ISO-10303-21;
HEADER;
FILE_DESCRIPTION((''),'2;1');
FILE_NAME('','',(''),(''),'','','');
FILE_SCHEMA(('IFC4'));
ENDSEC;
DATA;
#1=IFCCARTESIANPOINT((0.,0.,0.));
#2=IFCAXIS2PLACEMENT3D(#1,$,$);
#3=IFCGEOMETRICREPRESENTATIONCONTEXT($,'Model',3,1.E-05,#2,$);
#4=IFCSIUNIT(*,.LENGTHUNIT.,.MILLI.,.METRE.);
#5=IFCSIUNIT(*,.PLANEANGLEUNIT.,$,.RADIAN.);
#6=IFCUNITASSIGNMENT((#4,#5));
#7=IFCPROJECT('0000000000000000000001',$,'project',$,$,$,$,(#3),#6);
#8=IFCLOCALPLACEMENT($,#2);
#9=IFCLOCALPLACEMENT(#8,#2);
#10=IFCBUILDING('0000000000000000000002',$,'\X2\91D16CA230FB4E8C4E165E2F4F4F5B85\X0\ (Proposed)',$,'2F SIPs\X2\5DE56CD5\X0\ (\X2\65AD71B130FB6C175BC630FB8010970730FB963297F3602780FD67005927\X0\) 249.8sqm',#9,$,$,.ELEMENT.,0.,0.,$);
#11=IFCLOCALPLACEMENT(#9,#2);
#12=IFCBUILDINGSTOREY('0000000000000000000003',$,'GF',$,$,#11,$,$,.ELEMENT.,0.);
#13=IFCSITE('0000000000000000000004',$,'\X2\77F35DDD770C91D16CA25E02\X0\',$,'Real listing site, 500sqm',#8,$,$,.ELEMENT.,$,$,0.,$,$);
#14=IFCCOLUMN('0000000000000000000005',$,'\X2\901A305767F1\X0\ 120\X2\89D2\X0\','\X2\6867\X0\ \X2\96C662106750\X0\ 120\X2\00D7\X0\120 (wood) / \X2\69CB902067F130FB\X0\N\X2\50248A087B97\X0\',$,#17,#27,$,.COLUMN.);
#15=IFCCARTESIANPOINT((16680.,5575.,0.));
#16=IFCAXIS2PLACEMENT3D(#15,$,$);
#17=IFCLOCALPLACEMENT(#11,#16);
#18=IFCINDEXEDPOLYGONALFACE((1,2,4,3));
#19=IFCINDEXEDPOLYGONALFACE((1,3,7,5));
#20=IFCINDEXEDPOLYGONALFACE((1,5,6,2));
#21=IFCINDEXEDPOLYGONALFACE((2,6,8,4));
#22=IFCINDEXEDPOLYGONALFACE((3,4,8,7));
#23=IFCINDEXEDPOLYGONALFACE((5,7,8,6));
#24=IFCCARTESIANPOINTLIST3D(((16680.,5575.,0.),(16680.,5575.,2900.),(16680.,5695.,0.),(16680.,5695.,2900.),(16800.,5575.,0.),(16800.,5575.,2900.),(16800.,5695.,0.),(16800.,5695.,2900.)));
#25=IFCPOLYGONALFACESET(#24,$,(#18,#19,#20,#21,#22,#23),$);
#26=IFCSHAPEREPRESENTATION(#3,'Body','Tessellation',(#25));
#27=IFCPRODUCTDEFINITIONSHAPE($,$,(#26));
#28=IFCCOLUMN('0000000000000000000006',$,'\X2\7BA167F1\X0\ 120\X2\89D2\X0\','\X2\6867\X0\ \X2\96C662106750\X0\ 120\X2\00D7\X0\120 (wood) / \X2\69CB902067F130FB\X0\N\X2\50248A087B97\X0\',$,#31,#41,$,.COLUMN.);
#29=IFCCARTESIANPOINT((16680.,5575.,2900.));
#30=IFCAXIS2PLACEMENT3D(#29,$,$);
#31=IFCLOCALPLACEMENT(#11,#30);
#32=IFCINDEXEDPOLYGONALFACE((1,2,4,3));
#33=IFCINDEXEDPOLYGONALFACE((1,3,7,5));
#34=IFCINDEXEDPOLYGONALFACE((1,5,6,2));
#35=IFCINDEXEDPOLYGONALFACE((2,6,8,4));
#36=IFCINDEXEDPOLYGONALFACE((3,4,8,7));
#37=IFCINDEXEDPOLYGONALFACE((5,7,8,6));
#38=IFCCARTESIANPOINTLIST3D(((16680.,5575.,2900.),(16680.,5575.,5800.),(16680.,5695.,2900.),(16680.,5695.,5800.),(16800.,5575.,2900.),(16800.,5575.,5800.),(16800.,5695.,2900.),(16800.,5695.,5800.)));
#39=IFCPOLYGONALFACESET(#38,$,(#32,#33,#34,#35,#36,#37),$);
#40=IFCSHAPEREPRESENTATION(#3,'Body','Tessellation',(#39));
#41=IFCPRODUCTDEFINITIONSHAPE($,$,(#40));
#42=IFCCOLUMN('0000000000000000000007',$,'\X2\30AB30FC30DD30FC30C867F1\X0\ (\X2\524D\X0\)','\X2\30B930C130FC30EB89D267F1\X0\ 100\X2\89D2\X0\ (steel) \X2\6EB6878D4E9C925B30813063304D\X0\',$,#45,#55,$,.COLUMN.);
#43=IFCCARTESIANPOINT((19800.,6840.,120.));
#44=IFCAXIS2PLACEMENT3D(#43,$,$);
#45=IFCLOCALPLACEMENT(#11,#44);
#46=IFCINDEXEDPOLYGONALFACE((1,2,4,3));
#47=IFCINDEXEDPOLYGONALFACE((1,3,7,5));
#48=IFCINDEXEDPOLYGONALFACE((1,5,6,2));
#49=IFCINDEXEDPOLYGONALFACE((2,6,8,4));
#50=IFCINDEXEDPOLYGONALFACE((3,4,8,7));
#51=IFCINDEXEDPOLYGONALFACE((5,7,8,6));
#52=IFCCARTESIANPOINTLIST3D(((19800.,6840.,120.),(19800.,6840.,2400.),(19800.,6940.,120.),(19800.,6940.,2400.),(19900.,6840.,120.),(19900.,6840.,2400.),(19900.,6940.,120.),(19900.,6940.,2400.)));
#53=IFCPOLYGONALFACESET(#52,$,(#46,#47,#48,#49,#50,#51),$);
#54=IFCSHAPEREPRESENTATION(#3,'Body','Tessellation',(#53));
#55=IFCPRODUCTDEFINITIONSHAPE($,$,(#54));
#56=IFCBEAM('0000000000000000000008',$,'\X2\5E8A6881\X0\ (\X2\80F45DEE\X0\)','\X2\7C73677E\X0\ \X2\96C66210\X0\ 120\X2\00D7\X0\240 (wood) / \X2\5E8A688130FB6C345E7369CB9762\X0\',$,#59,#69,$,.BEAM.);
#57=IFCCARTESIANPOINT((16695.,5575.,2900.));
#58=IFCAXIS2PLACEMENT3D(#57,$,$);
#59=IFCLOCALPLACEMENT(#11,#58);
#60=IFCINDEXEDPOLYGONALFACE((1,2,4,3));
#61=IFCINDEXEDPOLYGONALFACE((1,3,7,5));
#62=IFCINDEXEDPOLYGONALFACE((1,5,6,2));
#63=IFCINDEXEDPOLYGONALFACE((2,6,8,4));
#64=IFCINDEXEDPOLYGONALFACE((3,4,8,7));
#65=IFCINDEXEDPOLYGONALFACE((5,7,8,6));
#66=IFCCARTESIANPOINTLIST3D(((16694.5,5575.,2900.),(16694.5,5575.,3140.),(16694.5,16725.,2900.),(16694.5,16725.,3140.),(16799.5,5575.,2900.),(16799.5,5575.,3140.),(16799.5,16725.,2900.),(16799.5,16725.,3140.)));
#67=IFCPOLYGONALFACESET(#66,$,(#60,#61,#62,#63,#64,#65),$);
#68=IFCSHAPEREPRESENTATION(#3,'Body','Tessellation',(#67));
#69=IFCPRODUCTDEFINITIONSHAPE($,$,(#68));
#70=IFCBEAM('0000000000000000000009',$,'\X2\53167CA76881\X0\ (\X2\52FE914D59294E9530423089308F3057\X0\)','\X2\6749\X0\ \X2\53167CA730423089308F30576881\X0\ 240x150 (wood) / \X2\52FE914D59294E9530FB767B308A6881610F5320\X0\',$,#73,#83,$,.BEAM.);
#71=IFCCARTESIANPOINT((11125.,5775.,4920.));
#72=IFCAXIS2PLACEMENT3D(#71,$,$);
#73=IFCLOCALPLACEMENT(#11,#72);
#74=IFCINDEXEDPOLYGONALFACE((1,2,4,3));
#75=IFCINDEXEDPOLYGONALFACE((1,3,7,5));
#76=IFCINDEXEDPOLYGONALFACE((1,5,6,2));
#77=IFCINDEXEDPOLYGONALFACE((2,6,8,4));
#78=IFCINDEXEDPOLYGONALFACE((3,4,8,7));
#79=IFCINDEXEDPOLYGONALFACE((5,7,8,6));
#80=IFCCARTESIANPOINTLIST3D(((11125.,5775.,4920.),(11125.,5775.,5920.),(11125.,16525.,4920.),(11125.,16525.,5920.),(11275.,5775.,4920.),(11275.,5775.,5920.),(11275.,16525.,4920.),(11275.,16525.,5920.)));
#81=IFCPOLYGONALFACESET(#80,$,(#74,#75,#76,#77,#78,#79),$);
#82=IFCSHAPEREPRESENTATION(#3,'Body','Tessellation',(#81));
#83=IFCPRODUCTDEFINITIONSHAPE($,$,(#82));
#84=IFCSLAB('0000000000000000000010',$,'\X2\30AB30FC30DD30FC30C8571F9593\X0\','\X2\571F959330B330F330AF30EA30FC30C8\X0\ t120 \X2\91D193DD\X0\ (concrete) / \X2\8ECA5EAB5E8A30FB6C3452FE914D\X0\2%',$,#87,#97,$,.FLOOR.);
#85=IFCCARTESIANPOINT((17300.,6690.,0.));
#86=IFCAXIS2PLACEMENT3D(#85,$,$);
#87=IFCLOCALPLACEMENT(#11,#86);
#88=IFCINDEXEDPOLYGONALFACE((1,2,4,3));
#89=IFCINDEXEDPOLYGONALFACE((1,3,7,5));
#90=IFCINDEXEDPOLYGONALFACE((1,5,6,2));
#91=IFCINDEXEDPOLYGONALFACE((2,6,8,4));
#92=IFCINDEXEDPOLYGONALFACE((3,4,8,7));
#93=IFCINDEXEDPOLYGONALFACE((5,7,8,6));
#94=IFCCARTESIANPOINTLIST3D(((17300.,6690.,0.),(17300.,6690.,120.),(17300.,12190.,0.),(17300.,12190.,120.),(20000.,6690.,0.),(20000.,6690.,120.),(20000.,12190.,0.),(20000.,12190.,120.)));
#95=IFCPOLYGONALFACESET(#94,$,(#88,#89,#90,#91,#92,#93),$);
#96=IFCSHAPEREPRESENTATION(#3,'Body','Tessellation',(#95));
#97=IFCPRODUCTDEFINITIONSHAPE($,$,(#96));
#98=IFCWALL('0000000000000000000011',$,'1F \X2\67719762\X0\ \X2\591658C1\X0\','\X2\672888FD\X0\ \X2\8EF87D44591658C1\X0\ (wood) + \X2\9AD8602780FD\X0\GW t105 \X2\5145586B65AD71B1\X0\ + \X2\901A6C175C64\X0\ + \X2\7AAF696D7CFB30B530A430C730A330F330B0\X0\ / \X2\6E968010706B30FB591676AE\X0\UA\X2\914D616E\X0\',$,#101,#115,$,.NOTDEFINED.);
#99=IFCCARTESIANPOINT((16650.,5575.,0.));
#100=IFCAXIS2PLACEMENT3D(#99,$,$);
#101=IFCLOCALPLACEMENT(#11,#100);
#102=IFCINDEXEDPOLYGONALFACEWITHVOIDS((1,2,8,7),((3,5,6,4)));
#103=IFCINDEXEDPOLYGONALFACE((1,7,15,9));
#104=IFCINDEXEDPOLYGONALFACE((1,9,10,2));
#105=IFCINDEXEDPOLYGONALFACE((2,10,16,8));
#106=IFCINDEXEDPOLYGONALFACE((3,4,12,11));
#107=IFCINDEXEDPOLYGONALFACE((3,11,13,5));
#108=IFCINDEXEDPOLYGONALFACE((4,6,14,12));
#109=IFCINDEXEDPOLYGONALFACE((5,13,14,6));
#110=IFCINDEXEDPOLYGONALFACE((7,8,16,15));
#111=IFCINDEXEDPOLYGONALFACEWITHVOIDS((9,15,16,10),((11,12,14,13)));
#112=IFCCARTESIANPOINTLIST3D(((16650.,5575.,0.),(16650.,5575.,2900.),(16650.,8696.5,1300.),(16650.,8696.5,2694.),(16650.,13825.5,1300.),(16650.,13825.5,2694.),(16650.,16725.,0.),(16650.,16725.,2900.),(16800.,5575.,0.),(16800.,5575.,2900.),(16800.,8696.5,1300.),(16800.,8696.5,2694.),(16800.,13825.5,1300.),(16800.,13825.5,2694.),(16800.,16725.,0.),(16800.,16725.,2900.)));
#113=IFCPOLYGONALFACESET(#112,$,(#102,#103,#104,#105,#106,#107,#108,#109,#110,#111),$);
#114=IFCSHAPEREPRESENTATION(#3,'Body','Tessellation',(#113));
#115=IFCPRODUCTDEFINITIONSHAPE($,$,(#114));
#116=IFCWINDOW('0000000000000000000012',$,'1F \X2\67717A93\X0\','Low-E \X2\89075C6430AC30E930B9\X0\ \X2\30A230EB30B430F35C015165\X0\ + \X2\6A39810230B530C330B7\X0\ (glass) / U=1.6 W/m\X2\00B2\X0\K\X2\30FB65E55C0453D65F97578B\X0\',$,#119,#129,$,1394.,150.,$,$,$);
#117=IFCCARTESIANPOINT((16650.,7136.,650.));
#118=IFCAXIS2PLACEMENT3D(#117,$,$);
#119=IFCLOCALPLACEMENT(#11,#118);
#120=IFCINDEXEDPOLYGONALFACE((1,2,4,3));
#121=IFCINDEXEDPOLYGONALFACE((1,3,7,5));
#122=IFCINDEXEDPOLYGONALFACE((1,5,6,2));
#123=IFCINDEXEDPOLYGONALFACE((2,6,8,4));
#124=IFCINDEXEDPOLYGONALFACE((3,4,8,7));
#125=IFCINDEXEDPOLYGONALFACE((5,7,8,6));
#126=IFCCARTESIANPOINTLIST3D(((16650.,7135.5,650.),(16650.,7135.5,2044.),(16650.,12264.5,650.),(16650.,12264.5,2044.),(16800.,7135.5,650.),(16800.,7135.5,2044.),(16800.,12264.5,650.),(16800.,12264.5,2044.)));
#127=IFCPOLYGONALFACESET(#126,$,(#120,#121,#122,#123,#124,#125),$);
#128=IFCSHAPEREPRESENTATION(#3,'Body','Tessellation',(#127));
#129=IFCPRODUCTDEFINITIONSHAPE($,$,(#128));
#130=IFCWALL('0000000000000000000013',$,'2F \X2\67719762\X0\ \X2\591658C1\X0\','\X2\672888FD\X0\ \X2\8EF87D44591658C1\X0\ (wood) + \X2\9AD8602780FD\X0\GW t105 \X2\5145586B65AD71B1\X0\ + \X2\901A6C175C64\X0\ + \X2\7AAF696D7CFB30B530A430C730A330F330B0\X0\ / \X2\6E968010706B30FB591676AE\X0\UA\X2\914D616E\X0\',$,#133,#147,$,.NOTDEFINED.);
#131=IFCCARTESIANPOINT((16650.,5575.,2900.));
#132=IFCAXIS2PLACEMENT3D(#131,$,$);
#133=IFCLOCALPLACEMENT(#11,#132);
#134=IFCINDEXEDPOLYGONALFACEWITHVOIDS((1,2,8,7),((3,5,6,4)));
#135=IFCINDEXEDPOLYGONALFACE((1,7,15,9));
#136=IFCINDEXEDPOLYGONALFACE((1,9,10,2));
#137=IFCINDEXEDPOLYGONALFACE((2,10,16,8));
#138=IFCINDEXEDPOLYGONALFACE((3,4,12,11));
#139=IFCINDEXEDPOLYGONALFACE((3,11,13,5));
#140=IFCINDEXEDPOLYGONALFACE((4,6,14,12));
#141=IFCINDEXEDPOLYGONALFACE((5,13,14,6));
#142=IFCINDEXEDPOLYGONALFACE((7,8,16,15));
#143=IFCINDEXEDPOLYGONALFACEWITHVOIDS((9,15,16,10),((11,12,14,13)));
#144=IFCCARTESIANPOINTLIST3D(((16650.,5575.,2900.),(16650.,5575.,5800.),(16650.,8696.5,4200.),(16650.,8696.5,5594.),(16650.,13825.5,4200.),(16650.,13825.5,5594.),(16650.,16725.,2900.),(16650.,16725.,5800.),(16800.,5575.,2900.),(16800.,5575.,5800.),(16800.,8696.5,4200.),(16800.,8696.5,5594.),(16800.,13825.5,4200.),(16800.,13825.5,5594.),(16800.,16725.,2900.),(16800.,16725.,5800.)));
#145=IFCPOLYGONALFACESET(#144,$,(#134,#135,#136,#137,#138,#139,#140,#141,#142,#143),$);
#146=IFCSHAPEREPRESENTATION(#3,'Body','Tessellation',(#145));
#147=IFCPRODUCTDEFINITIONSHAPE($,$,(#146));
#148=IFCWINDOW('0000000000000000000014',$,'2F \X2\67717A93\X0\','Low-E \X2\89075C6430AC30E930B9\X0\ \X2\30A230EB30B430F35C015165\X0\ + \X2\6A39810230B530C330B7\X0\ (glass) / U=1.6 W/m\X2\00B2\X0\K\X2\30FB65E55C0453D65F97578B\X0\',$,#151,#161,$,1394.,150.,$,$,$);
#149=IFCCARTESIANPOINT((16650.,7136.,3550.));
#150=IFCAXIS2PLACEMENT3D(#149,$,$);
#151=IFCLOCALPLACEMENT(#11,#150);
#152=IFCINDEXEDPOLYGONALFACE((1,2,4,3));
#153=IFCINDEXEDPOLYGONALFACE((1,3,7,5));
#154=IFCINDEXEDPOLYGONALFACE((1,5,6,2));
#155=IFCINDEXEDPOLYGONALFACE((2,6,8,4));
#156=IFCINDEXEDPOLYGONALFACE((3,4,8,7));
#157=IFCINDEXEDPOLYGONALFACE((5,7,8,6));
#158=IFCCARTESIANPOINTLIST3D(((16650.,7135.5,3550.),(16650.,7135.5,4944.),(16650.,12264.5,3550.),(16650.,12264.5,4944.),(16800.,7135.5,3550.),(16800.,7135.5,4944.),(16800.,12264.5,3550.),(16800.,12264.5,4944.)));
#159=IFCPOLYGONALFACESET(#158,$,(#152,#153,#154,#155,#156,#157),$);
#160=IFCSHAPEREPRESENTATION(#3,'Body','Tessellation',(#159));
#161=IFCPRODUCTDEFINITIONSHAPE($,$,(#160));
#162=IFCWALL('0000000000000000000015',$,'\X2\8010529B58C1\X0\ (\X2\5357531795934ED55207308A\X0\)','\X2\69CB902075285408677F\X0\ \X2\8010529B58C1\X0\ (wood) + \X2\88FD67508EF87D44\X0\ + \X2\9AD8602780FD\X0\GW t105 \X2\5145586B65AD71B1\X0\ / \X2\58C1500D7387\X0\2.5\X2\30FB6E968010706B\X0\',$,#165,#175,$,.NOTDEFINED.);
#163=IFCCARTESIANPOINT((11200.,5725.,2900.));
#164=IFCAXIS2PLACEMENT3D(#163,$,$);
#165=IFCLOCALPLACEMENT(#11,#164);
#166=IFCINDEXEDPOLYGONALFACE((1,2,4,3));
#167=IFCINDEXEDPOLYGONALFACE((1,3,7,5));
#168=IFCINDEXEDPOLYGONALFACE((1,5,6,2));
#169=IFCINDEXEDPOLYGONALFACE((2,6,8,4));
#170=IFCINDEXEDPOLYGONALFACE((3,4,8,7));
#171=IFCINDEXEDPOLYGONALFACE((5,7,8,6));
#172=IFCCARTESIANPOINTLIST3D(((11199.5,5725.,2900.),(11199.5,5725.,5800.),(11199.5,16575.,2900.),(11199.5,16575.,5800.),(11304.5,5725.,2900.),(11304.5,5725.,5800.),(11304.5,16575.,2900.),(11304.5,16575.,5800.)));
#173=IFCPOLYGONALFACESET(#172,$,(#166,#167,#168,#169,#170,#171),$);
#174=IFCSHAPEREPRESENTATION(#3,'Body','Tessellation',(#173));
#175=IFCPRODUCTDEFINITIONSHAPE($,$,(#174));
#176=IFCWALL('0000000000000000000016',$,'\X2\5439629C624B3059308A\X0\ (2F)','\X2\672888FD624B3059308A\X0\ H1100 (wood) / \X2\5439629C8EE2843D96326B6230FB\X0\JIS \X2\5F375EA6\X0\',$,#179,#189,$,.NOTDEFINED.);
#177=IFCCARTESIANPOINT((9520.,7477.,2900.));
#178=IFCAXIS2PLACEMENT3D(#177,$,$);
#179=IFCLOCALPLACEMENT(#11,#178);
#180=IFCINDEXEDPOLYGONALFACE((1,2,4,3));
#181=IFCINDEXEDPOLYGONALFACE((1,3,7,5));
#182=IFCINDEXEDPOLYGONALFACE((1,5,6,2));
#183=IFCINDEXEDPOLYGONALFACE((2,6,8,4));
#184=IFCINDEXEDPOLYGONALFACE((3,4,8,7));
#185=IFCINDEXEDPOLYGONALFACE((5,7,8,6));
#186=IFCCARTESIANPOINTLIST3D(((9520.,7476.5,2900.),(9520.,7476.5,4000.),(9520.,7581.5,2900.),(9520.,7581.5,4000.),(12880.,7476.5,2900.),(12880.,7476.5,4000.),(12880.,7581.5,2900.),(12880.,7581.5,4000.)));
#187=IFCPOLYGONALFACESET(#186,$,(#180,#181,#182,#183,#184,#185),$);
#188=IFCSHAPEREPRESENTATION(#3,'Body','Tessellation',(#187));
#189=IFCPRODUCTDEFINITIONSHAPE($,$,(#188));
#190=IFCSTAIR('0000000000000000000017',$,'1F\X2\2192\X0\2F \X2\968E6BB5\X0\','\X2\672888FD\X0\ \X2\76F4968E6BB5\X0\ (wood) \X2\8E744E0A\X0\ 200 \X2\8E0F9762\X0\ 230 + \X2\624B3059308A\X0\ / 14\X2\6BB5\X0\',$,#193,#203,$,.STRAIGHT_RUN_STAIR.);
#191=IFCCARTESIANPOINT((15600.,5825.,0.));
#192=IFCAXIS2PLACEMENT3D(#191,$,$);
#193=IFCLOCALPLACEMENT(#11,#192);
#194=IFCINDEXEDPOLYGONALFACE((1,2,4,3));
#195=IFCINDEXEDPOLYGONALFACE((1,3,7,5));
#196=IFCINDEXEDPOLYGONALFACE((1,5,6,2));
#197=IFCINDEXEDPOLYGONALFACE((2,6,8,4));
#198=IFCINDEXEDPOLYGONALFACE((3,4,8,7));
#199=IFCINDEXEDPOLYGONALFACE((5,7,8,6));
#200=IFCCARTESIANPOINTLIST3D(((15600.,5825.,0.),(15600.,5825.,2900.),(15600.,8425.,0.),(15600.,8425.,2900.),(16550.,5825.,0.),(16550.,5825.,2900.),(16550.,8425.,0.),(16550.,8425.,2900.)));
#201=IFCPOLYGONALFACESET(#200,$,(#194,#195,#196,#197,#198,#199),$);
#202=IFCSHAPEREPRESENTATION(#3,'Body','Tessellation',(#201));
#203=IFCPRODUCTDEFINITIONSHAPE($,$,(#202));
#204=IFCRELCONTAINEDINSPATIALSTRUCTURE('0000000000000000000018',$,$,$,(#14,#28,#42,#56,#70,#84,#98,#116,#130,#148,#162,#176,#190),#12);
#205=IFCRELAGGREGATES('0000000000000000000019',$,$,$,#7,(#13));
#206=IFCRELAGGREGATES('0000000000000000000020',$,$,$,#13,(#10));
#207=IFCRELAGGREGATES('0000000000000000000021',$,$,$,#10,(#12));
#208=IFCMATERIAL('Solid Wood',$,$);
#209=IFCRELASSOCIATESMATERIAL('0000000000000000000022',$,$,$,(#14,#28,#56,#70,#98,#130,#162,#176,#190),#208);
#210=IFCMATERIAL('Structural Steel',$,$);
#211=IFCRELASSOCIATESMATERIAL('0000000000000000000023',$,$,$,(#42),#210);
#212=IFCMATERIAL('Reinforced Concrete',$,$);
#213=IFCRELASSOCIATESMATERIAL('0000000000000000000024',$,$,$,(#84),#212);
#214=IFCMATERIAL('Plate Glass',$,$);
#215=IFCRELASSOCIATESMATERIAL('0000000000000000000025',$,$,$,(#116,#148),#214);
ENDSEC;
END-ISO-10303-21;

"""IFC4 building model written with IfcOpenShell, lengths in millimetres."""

from ifc_helpers import new_model, si_unit, frame, frame_2d, origin, place, context, project, spatial, rectangle, extrude, material, element, fill, save


model = new_model("IFC4")

# Units and contexts
model_context = context("Model", 3, precision=1e-05, world=origin())
ifc_project = project(units=[si_unit("LENGTHUNIT", "METRE", prefix="MILLI"), si_unit("PLANEANGLEUNIT", "RADIAN")], contexts=[model_context])

# Site, building, storey
site_placement = place(None, origin())
site = spatial("IfcSite", under=ifc_project, at=site_placement, Name="石川県金沢市", ObjectType="Real listing site, 500sqm", CompositionType="ELEMENT", RefElevation=0.0)
building_placement = place(site_placement, origin())
building = spatial("IfcBuilding", under=site, at=building_placement, Name="金沢・二世帯住宅 (Proposed)", ObjectType="2F SIPs工法 (断熱・気密・耐震・防音性能最大) 249.8sqm", CompositionType="ELEMENT", ElevationOfRefHeight=0.0, ElevationOfTerrain=0.0)
storey_placement = place(building_placement, origin())
storey = spatial("IfcBuildingStorey", under=building, at=storey_placement, Name="GF", CompositionType="ELEMENT", Elevation=0.0)

# Columns
ifc_material_1 = material(Name="Solid Wood")
column_1_placement = place(storey_placement, frame((16680.0, 5575.0, 0.0)))
element("IfcColumn", 1, at=column_1_placement, inside=storey, material=ifc_material_1, Name="通し柱 120角", Description="桧 集成材 120×120 (wood) / 構造柱・N値計算", PredefinedType="COLUMN", context=model_context, shape_type="SweptSolid", body=[
    extrude(rectangle(XDim=120.0, YDim=120.0, at=frame_2d((60.0, 60.0))), frame((16680.0, 5575.0, 0.0)), (0.0, 0.0, 1.0), 2900.0),
])
column_2_placement = place(storey_placement, frame((16680.0, 5575.0, 2900.0)))
element("IfcColumn", 2, at=column_2_placement, inside=storey, material=ifc_material_1, Name="管柱 120角", Description="桧 集成材 120×120 (wood) / 構造柱・N値計算", PredefinedType="COLUMN", context=model_context, shape_type="SweptSolid", body=[
    extrude(rectangle(XDim=120.0, YDim=120.0, at=frame_2d((60.0, 60.0))), frame((16680.0, 5575.0, 2900.0)), (0.0, 0.0, 1.0), 2900.0),
])
ifc_material_2 = material(Name="Structural Steel")
column_3_placement = place(storey_placement, frame((19800.0, 6840.0, 120.0)))
element("IfcColumn", 3, at=column_3_placement, inside=storey, material=ifc_material_2, Name="カーポート柱 (前)", Description="スチール角柱 100角 (steel) 溶融亜鉛めっき", PredefinedType="COLUMN", context=model_context, shape_type="SweptSolid", body=[
    extrude(rectangle(XDim=100.0, YDim=100.0, at=frame_2d((50.0, 50.0))), frame((19800.0, 6840.0, 120.0)), (0.0, 0.0, 1.0), 2280.0),
])

# Beams
beam_1_placement = place(storey_placement, frame((16695.0, 5575.0, 2900.0)))
element("IfcBeam", 4, at=beam_1_placement, inside=storey, material=ifc_material_1, Name="床梁 (胴差)", Description="米松 集成 120×240 (wood) / 床梁・水平構面", PredefinedType="BEAM", context=model_context, shape_type="SweptSolid", body=[
    extrude(rectangle(XDim=105.0, YDim=11150.0, at=frame_2d((52.0, 5575.0))), frame((16695.0, 5575.0, 2900.0)), (0.0, 0.0, 1.0), 240.0),
])
beam_2_placement = place(storey_placement, frame((11125.0, 5775.0, 4920.0)))
element("IfcBeam", 5, at=beam_2_placement, inside=storey, material=ifc_material_1, Name="化粧梁 (勾配天井あらわし)", Description="杉 化粧あらわし梁 240x150 (wood) / 勾配天井・登り梁意匠", PredefinedType="BEAM", context=model_context, shape_type="SweptSolid", body=[
    extrude(rectangle(XDim=150.0, YDim=10750.0, at=frame_2d((75.0, 5375.0))), frame((11125.0, 5775.0, 4920.0)), (0.0, 0.0, 1.0), 1000.0),
])

# Slab
ifc_material_3 = material(Name="Reinforced Concrete")
slab_placement = place(storey_placement, frame((17300.0, 6690.0, 0.0)))
element("IfcSlab", 6, at=slab_placement, inside=storey, material=ifc_material_3, Name="カーポート土間", Description="土間コンクリート t120 金鏝 (concrete) / 車庫床・水勾配2%", PredefinedType="FLOOR", context=model_context, shape_type="SweptSolid", body=[
    extrude(rectangle(XDim=2700.0, YDim=5500.0, at=frame_2d((1350.0, 2750.0))), frame((17300.0, 6690.0, 0.0)), (0.0, 0.0, 1.0), 120.0),
])

# Wall, opening, window
wall_1_placement = place(storey_placement, frame((16650.0, 5575.0, 0.0)))
wall_1 = element("IfcWall", 7, at=wall_1_placement, inside=storey, material=ifc_material_1, Name="1F 東面 外壁", Description="木製 軸組外壁 (wood) + 高性能GW t105 充填断熱 + 通気層 + 窯業系サイディング / 準耐火・外皮UA配慮", PredefinedType="NOTDEFINED", context=model_context, shape_type="SweptSolid", body=[
    extrude(rectangle(XDim=150.0, YDim=11150.0, at=frame_2d((75.0, 5575.0))), frame((16650.0, 5575.0, 0.0)), (0.0, 0.0, 1.0), 2900.0),
])
opening_1_placement = place(storey_placement, frame((16650.0, 7136.0, 650.0)))
opening_1 = element("IfcOpeningElement", 8, at=opening_1_placement, cuts=wall_1, PredefinedType="NOTDEFINED", context=model_context, shape_type="SweptSolid", body=[
    extrude(rectangle(XDim=150.0, YDim=5129.0, at=frame_2d((75.0, 2564.0))), frame((16650.0, 7136.0, 650.0)), (0.0, 0.0, 1.0), 1394.0),
])
ifc_material_4 = material(Name="Plate Glass")
window_1_placement = place(storey_placement, frame((16650.0, 7136.0, 650.0)))
window_1 = element("IfcWindow", 9, at=window_1_placement, inside=storey, material=ifc_material_4, Name="1F 東窓", Description="Low-E 複層ガラス アルゴン封入 + 樹脂サッシ (glass) / U=1.6 W/m²K・日射取得型", OverallHeight=1394.0, OverallWidth=150.0, context=model_context, shape_type="SweptSolid", body=[
    extrude(rectangle(XDim=150.0, YDim=5129.0, at=frame_2d((75.0, 2564.0))), frame((16650.0, 7136.0, 650.0)), (0.0, 0.0, 1.0), 1394.0),
])
fill(opening_1, window_1)

# Wall, opening, window
wall_2_placement = place(storey_placement, frame((16650.0, 5575.0, 2900.0)))
wall_2 = element("IfcWall", 10, at=wall_2_placement, inside=storey, material=ifc_material_1, Name="2F 東面 外壁", Description="木製 軸組外壁 (wood) + 高性能GW t105 充填断熱 + 通気層 + 窯業系サイディング / 準耐火・外皮UA配慮", PredefinedType="NOTDEFINED", context=model_context, shape_type="SweptSolid", body=[
    extrude(rectangle(XDim=150.0, YDim=11150.0, at=frame_2d((75.0, 5575.0))), frame((16650.0, 5575.0, 2900.0)), (0.0, 0.0, 1.0), 2900.0),
])
opening_2_placement = place(storey_placement, frame((16650.0, 7136.0, 3550.0)))
opening_2 = element("IfcOpeningElement", 11, at=opening_2_placement, cuts=wall_2, PredefinedType="NOTDEFINED", context=model_context, shape_type="SweptSolid", body=[
    extrude(rectangle(XDim=150.0, YDim=5129.0, at=frame_2d((75.0, 2564.0))), frame((16650.0, 7136.0, 3550.0)), (0.0, 0.0, 1.0), 1394.0),
])
window_2_placement = place(storey_placement, frame((16650.0, 7136.0, 3550.0)))
window_2 = element("IfcWindow", 12, at=window_2_placement, inside=storey, material=ifc_material_4, Name="2F 東窓", Description="Low-E 複層ガラス アルゴン封入 + 樹脂サッシ (glass) / U=1.6 W/m²K・日射取得型", OverallHeight=1394.0, OverallWidth=150.0, context=model_context, shape_type="SweptSolid", body=[
    extrude(rectangle(XDim=150.0, YDim=5129.0, at=frame_2d((75.0, 2564.0))), frame((16650.0, 7136.0, 3550.0)), (0.0, 0.0, 1.0), 1394.0),
])
fill(opening_2, window_2)

# Walls
wall_3_placement = place(storey_placement, frame((11200.0, 5725.0, 2900.0)))
element("IfcWall", 13, at=wall_3_placement, inside=storey, material=ifc_material_1, Name="耐力壁 (南北間仕切り)", Description="構造用合板 耐力壁 (wood) + 製材軸組 + 高性能GW t105 充填断熱 / 壁倍率2.5・準耐火", PredefinedType="NOTDEFINED", context=model_context, shape_type="SweptSolid", body=[
    extrude(rectangle(XDim=105.0, YDim=10850.0, at=frame_2d((52.0, 5425.0))), frame((11200.0, 5725.0, 2900.0)), (0.0, 0.0, 1.0), 2900.0),
])
wall_4_placement = place(storey_placement, frame((9520.0, 7477.0, 2900.0)))
element("IfcWall", 14, at=wall_4_placement, inside=storey, material=ifc_material_1, Name="吹抜手すり (2F)", Description="木製手すり H1100 (wood) / 吹抜転落防止・JIS 強度", PredefinedType="NOTDEFINED", context=model_context, shape_type="SweptSolid", body=[
    extrude(rectangle(XDim=3360.0, YDim=105.0, at=frame_2d((1680.0, 52.0))), frame((9520.0, 7477.0, 2900.0)), (0.0, 0.0, 1.0), 1100.0),
])

# Stair
stair_placement = place(storey_placement, frame((15600.0, 5825.0, 0.0)))
element("IfcStair", 15, at=stair_placement, inside=storey, material=ifc_material_1, Name="1F→2F 階段", Description="木製 直階段 (wood) 蹴上 200 踏面 230 + 手すり / 14段", PredefinedType="STRAIGHT_RUN_STAIR", context=model_context, shape_type="SweptSolid", body=[
    extrude(rectangle(XDim=950.0, YDim=2600.0, at=frame_2d((475.0, 1300.0))), frame((15600.0, 5825.0, 0.0)), (0.0, 0.0, 1.0), 2900.0),
])

save(model, "model.ifc")
